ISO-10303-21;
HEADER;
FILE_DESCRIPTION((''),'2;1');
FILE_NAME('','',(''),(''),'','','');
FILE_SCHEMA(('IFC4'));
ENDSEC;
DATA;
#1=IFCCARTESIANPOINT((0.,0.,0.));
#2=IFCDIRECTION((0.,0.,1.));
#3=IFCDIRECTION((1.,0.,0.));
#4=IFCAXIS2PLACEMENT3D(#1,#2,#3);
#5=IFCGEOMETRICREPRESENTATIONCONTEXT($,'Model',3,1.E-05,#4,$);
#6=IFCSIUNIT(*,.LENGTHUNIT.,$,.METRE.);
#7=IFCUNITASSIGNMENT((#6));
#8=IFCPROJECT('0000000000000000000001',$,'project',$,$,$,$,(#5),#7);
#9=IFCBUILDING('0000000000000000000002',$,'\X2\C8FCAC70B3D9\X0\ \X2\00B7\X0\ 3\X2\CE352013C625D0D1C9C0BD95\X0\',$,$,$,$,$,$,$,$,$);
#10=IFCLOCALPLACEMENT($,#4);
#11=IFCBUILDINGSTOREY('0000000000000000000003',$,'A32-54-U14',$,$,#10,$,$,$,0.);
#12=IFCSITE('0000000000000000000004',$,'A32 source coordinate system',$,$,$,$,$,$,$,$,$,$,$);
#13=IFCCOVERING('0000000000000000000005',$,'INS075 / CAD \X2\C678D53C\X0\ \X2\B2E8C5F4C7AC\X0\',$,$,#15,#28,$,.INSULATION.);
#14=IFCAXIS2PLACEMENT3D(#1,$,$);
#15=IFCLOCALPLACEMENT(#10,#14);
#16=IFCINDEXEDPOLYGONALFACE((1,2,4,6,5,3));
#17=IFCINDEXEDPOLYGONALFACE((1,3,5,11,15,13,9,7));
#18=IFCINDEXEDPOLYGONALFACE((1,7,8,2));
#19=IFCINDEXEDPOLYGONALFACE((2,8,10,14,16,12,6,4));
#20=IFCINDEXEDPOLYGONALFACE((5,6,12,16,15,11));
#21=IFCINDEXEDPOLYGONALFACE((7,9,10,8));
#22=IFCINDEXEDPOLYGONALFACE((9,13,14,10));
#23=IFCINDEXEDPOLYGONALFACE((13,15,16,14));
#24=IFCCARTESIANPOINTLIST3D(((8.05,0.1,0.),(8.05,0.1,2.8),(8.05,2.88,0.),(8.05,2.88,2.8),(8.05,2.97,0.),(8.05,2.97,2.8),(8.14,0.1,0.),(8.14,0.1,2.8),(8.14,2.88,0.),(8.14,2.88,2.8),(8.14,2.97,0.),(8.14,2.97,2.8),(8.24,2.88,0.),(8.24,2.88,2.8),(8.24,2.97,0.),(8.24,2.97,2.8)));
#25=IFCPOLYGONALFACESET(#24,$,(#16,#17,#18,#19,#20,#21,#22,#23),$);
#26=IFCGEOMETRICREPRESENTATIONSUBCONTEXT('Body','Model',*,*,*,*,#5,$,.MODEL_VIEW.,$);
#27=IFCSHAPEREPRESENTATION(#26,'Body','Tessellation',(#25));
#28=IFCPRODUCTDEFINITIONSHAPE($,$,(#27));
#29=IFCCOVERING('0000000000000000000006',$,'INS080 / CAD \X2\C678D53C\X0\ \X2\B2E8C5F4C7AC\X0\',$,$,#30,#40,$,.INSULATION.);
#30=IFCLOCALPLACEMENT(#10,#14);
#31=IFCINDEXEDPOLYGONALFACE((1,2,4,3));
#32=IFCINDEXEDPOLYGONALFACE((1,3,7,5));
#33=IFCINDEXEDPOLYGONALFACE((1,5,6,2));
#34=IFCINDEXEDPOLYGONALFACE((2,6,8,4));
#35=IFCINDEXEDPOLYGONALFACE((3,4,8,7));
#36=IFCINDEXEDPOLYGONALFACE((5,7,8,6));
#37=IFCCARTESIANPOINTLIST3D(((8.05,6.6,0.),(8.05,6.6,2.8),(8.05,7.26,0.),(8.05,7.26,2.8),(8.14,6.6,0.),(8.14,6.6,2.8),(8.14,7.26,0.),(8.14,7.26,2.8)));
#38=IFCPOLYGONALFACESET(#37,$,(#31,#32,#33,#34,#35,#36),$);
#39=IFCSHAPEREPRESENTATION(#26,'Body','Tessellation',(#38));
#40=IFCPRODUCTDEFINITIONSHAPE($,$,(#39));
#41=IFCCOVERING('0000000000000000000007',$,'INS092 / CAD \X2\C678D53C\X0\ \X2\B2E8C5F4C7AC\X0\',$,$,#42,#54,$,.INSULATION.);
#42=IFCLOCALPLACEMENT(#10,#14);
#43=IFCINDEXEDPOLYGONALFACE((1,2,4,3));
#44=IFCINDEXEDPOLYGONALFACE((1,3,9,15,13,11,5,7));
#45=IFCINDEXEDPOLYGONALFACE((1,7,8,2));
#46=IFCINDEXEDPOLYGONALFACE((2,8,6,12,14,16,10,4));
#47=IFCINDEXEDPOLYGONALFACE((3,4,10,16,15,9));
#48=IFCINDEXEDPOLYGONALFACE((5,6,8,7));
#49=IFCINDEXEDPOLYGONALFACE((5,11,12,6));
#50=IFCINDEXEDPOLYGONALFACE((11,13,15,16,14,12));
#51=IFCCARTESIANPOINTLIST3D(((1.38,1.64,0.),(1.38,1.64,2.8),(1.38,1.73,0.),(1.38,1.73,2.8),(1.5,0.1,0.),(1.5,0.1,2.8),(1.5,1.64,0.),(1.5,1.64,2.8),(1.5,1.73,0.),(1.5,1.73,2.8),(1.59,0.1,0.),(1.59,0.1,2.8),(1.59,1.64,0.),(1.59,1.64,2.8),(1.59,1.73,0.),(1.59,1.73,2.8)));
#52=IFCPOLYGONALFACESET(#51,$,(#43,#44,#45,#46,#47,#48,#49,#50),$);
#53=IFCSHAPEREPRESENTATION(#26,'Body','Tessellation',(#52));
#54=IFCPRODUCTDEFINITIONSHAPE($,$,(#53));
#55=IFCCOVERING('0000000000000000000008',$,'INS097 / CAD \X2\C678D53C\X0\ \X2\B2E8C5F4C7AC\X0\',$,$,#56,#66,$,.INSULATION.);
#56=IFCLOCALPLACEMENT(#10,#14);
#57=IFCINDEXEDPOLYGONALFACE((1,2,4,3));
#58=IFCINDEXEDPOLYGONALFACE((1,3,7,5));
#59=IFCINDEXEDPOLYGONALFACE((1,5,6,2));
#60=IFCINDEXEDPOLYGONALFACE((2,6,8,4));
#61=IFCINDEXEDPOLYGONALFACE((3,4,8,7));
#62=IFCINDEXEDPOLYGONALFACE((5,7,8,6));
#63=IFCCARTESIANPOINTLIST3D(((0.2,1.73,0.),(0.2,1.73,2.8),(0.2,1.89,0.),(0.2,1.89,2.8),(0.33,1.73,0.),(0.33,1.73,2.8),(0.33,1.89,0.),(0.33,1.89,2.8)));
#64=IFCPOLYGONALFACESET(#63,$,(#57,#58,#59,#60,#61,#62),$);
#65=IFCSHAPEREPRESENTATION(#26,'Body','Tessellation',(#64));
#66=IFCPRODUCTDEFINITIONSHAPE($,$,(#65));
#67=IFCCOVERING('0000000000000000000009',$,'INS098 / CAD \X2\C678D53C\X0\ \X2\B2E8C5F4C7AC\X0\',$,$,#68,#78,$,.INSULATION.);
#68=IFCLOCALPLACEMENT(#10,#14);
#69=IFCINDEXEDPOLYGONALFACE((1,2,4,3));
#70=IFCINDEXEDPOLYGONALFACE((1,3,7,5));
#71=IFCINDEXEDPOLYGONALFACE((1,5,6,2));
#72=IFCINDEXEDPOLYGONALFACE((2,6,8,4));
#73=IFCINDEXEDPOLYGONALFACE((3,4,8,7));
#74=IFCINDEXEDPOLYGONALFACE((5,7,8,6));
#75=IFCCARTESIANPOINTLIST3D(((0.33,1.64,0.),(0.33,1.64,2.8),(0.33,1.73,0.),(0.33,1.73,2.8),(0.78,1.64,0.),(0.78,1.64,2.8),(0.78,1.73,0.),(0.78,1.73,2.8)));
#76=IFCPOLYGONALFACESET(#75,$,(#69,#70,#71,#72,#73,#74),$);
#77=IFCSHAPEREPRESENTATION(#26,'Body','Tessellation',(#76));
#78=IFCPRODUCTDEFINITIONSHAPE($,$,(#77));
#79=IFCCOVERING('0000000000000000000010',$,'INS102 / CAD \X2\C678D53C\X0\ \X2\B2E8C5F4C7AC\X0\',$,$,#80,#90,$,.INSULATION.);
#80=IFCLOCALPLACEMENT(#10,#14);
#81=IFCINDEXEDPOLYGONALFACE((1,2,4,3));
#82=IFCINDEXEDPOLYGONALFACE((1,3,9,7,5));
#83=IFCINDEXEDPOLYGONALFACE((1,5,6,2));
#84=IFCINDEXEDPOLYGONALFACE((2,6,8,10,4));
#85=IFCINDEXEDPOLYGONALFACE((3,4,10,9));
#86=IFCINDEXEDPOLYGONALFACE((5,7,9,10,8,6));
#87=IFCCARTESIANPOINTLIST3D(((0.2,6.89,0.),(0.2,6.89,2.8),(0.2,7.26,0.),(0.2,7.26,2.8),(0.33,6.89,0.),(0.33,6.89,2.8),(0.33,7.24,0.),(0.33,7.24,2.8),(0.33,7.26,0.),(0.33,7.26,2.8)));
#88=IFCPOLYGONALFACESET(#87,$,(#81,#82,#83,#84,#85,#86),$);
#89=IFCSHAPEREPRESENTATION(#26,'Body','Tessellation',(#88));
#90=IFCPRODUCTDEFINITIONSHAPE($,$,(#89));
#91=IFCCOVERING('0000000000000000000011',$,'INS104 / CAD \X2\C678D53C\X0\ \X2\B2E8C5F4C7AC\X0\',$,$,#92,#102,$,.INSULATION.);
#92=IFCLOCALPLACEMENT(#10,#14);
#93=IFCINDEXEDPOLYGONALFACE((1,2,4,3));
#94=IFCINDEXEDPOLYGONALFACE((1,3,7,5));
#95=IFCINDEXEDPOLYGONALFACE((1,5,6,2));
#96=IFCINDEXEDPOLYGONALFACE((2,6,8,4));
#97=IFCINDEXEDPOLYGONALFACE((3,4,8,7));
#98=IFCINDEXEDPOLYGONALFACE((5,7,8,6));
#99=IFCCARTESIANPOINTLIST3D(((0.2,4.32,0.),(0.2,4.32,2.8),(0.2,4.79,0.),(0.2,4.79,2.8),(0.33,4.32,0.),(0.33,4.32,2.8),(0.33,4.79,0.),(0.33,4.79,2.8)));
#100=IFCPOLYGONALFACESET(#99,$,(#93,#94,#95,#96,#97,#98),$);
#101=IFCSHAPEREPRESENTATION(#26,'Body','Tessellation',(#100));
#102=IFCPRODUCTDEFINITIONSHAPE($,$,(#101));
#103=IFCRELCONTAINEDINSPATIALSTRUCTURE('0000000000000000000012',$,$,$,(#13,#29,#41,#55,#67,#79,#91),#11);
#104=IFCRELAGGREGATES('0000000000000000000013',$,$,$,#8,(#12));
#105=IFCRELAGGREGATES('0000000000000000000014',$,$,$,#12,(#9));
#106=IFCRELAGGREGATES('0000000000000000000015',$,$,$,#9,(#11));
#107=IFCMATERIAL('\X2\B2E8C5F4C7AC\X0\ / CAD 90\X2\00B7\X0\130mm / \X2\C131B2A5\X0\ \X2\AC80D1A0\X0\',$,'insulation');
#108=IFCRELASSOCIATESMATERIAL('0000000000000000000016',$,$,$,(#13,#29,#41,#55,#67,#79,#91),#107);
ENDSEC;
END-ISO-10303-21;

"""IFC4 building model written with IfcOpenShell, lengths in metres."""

from ifc_helpers import new_model, si_unit, origin, origin_with_axes, place, context, subcontext, project, spatial, polyline, outline, extrude, material, element, save


model = new_model("IFC4")

# Units and contexts
model_context = context("Model", 3, precision=1e-05, world=origin_with_axes())
body_context = subcontext(model_context, "Body", "Model", "MODEL_VIEW")
ifc_project = project(units=[si_unit("LENGTHUNIT", "METRE")], contexts=[model_context])

# Site, building, storey
storey_placement = place(None, origin_with_axes())
site = spatial("IfcSite", under=ifc_project, Name="A32 source coordinate system")
building = spatial("IfcBuilding", under=site, Name="주거동 · 3층–옥탑지붕")
storey = spatial("IfcBuildingStorey", under=building, at=storey_placement, Name="A32-54-U14", Elevation=0.0)

# Coverings
ifc_material = material(Name="단열재 / CAD 90·130mm / 성능 검토", Category="insulation")
covering_1_placement = place(storey_placement, origin_with_axes())
element("IfcCovering", 1, at=covering_1_placement, inside=storey, material=ifc_material, Name="INS075 / CAD 외피 단열재", PredefinedType="INSULATION", context=body_context, shape_type="SweptSolid", body=[
    extrude(outline(polyline([(8.24, 2.88), (8.14, 2.88), (8.14, 0.1), (8.05, 0.1), (8.05, 2.88), (8.05, 2.97), (8.14, 2.97), (8.24, 2.97), (8.24, 2.88)])), origin(), (0.0, 0.0, 1.0), 2.8),
])
covering_2_placement = place(storey_placement, origin_with_axes())
element("IfcCovering", 2, at=covering_2_placement, inside=storey, material=ifc_material, Name="INS080 / CAD 외피 단열재", PredefinedType="INSULATION", context=body_context, shape_type="SweptSolid", body=[
    extrude(outline(polyline([(8.14, 7.26), (8.14, 6.6), (8.05, 6.6), (8.05, 7.26), (8.14, 7.26)])), origin(), (0.0, 0.0, 1.0), 2.8),
])
covering_3_placement = place(storey_placement, origin_with_axes())
element("IfcCovering", 3, at=covering_3_placement, inside=storey, material=ifc_material, Name="INS092 / CAD 외피 단열재", PredefinedType="INSULATION", context=body_context, shape_type="SweptSolid", body=[
    extrude(outline(polyline([(1.59, 1.73), (1.59, 1.64), (1.59, 0.1), (1.5, 0.1), (1.5, 1.64), (1.38, 1.64), (1.38, 1.73), (1.5, 1.73), (1.59, 1.73)])), origin(), (0.0, 0.0, 1.0), 2.8),
])
covering_4_placement = place(storey_placement, origin_with_axes())
element("IfcCovering", 4, at=covering_4_placement, inside=storey, material=ifc_material, Name="INS097 / CAD 외피 단열재", PredefinedType="INSULATION", context=body_context, shape_type="SweptSolid", body=[
    extrude(outline(polyline([(0.33, 1.89), (0.33, 1.73), (0.2, 1.73), (0.2, 1.89), (0.33, 1.89)])), origin(), (0.0, 0.0, 1.0), 2.8),
])
covering_5_placement = place(storey_placement, origin_with_axes())
element("IfcCovering", 5, at=covering_5_placement, inside=storey, material=ifc_material, Name="INS098 / CAD 외피 단열재", PredefinedType="INSULATION", context=body_context, shape_type="SweptSolid", body=[
    extrude(outline(polyline([(0.78, 1.73), (0.78, 1.64), (0.33, 1.64), (0.33, 1.73), (0.78, 1.73)])), origin(), (0.0, 0.0, 1.0), 2.8),
])
covering_6_placement = place(storey_placement, origin_with_axes())
element("IfcCovering", 6, at=covering_6_placement, inside=storey, material=ifc_material, Name="INS102 / CAD 외피 단열재", PredefinedType="INSULATION", context=body_context, shape_type="SweptSolid", body=[
    extrude(outline(polyline([(0.33, 7.26), (0.33, 7.24), (0.33, 6.89), (0.2, 6.89), (0.2, 7.26), (0.33, 7.26)])), origin(), (0.0, 0.0, 1.0), 2.8),
])
covering_7_placement = place(storey_placement, origin_with_axes())
element("IfcCovering", 7, at=covering_7_placement, inside=storey, material=ifc_material, Name="INS104 / CAD 외피 단열재", PredefinedType="INSULATION", context=body_context, shape_type="SweptSolid", body=[
    extrude(outline(polyline([(0.33, 4.32), (0.2, 4.32), (0.2, 4.79), (0.33, 4.79), (0.33, 4.32)])), origin(), (0.0, 0.0, 1.0), 2.8),
])

save(model, "model.ifc")
